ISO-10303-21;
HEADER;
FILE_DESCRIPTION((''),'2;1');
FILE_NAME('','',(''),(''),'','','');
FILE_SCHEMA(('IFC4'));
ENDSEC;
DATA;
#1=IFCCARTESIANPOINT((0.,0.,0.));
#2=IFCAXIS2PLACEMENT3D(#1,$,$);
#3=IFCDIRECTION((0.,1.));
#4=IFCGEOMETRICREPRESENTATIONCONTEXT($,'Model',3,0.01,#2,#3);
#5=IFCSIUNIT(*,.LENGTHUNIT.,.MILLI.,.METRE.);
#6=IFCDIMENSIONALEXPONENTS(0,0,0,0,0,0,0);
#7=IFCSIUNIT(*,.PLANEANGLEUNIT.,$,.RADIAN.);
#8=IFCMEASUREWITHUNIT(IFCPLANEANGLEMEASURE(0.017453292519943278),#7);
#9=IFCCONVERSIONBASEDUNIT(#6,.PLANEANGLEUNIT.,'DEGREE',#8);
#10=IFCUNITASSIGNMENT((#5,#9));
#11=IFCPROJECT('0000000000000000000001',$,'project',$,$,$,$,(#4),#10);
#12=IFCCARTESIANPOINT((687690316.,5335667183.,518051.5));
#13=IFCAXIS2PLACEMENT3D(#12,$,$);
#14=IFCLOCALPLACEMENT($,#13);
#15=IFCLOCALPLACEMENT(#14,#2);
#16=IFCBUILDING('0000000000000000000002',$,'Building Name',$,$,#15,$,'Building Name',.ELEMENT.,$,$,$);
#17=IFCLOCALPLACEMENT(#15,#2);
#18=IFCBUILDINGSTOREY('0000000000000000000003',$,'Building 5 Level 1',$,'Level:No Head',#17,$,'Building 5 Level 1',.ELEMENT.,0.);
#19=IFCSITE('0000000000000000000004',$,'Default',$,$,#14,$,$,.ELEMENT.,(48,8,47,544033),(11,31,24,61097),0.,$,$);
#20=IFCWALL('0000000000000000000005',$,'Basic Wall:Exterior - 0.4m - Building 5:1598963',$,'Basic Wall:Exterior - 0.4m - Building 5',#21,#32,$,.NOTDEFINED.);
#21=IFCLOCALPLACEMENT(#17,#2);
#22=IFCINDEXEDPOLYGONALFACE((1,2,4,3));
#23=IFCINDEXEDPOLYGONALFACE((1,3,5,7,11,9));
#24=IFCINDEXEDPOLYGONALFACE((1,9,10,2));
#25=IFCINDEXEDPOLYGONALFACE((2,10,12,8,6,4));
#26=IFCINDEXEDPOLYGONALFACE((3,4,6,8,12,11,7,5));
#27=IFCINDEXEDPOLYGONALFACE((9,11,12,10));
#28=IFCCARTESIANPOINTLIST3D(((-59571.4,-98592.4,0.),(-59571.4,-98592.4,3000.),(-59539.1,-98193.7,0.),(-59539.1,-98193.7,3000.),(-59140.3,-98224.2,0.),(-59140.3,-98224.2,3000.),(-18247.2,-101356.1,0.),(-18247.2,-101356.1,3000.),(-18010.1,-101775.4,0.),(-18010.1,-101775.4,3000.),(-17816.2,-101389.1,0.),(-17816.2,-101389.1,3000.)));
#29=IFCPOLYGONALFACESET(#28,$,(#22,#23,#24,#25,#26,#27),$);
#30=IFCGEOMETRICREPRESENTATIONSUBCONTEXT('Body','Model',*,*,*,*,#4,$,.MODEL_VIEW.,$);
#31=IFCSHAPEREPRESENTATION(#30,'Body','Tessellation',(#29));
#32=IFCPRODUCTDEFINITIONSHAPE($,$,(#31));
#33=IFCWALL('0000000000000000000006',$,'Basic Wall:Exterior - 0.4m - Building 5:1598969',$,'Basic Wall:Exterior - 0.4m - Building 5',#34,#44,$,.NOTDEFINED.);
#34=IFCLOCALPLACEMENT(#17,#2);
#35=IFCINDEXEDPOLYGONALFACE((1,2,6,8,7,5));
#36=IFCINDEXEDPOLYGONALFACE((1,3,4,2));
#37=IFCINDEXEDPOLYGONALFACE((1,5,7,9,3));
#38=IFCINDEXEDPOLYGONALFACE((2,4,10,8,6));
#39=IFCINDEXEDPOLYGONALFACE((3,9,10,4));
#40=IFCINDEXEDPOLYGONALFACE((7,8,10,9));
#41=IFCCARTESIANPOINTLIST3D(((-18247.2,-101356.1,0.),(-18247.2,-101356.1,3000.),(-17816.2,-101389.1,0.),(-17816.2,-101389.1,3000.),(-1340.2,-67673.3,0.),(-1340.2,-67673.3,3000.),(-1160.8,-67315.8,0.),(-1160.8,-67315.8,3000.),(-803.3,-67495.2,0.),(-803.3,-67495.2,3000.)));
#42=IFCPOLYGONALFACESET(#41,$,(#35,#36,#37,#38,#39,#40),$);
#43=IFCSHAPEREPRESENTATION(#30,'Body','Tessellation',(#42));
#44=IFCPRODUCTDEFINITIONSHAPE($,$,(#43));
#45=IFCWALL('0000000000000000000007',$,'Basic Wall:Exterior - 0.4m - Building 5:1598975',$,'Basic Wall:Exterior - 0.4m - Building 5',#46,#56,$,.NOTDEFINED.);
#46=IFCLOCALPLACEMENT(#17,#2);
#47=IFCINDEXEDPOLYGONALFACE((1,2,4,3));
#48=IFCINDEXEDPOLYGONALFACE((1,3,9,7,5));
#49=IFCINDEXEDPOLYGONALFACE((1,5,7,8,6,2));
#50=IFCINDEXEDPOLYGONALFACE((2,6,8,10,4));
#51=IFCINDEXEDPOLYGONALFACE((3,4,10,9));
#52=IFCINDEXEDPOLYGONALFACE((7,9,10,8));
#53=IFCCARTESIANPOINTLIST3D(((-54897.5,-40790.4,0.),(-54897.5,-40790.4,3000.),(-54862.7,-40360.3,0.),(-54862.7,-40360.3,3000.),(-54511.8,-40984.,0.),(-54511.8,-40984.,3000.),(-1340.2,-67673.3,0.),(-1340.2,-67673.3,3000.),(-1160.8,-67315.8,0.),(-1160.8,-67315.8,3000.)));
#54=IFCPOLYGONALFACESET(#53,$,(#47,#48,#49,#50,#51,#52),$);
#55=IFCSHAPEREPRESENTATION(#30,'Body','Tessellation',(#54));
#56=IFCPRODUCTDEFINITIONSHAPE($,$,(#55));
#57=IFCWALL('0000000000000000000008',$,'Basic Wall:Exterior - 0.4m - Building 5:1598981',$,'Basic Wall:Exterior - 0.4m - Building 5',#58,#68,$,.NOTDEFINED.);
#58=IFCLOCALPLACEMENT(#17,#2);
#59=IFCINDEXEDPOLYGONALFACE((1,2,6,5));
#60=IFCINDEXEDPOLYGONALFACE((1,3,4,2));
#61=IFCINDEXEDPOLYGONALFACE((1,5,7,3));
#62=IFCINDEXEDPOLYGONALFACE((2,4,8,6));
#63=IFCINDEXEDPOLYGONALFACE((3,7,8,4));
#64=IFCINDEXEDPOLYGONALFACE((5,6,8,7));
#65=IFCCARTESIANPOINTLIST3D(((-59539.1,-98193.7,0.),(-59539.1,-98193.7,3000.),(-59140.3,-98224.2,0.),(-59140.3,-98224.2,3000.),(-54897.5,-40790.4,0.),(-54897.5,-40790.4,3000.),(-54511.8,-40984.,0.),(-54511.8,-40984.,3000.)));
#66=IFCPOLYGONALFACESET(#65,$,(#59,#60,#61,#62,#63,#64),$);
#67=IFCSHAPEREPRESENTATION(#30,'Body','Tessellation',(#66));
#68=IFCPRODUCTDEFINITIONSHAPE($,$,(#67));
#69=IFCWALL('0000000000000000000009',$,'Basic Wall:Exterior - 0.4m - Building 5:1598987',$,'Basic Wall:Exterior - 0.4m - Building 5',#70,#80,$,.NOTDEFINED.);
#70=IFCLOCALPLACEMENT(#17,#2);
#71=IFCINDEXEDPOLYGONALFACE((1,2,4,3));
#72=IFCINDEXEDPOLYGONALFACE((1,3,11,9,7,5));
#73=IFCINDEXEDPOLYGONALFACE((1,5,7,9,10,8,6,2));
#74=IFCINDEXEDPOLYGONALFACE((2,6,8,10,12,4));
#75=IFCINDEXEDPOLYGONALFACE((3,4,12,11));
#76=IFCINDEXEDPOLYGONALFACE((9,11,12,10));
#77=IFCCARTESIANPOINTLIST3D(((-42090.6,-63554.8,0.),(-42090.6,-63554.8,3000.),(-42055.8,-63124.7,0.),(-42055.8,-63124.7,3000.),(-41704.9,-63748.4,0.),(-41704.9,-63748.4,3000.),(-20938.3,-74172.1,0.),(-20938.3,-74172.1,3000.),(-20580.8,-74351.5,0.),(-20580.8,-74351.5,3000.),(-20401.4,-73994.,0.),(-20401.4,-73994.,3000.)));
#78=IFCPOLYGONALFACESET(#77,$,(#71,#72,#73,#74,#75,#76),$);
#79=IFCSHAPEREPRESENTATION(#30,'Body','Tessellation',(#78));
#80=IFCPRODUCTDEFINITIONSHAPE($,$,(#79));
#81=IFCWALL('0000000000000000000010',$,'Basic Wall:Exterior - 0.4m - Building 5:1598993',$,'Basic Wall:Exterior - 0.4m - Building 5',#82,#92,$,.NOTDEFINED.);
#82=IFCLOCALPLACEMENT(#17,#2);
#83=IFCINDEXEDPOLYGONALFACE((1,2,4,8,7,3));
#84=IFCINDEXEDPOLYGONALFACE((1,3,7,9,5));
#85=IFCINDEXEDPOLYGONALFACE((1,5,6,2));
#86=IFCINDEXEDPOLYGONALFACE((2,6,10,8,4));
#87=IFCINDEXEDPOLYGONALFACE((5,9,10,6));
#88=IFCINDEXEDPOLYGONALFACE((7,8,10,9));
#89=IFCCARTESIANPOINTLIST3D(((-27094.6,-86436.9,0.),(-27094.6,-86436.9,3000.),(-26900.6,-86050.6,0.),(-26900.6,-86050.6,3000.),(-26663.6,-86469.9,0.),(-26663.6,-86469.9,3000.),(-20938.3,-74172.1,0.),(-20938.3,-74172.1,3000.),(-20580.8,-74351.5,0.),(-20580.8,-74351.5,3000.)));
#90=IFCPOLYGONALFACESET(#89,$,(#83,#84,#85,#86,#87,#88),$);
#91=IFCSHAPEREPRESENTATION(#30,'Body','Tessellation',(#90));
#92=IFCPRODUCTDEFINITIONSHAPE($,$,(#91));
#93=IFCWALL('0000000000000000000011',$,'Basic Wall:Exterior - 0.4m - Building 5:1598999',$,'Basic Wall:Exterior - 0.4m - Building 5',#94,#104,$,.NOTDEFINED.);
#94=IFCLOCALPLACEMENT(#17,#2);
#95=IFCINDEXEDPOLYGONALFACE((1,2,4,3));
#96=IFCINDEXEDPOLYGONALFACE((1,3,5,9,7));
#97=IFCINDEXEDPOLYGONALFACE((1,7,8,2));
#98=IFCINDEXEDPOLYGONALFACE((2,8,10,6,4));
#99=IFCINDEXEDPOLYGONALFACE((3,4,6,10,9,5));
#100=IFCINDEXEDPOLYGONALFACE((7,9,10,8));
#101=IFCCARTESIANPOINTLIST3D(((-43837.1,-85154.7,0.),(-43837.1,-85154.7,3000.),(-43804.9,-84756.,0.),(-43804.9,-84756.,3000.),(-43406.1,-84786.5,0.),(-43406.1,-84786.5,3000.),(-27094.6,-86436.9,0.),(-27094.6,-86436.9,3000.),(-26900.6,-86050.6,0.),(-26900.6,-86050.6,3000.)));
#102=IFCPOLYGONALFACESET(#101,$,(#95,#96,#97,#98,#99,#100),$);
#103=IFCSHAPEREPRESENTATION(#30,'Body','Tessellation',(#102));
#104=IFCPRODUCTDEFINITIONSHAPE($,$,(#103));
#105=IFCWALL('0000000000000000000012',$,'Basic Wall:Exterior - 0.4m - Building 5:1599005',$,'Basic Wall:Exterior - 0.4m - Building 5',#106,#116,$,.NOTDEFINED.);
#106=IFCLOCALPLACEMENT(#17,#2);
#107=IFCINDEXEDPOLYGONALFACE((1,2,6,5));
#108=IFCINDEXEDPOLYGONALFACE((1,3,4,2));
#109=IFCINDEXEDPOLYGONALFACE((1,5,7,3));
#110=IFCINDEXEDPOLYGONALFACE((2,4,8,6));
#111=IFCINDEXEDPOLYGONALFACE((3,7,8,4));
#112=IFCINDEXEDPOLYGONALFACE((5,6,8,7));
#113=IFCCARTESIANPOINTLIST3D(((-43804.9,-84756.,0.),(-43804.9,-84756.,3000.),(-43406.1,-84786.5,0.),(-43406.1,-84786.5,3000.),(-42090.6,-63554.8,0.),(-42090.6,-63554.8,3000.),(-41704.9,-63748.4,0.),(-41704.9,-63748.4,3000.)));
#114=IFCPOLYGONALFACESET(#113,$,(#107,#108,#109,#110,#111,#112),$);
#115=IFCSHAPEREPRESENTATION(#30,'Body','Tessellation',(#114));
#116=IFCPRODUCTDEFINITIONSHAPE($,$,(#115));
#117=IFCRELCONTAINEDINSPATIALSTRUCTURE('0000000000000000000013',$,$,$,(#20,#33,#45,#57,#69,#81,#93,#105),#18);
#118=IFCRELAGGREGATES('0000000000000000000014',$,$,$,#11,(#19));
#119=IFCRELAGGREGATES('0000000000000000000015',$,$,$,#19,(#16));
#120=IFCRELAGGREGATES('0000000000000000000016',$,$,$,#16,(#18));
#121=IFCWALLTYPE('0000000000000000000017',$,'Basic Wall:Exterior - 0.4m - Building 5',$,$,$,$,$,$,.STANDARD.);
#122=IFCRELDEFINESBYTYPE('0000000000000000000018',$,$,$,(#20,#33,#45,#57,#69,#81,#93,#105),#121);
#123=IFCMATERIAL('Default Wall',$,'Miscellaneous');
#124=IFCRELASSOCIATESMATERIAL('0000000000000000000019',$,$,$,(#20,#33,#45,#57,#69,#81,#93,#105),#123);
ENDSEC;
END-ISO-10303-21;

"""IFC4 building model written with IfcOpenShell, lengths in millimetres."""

from ifc_helpers import new_model, entity, si_unit, converted_unit, direction, frame, origin, place, context, subcontext, project, spatial, indexed_curve, outline, extrude, material, type_object, element, save


model = new_model("IFC4")

# Units and contexts
model_context = context("Model", 3, precision=0.01, world=origin(), true_north=direction((0.0, 1.0)))
body_context = subcontext(model_context, "Body", "Model", "MODEL_VIEW")
ifc_project = project(units=[si_unit("LENGTHUNIT", "METRE", prefix="MILLI"), converted_unit("PLANEANGLEUNIT", "DEGREE", entity("IfcPlaneAngleMeasure", 0.017453292519943278), si_unit("PLANEANGLEUNIT", "RADIAN"), dimensions=[0, 0, 0, 0, 0, 0, 0])], contexts=[model_context])

# Site, building, storey
site_placement = place(None, frame((687690316.0, 5335667183.0, 518051.5)))
site = spatial("IfcSite", under=ifc_project, at=site_placement, Name="Default", CompositionType="ELEMENT", RefLatitude=(48, 8, 47, 544033), RefLongitude=(11, 31, 24, 61097), RefElevation=0.0)
building_placement = place(site_placement, origin())
building = spatial("IfcBuilding", under=site, at=building_placement, Name="Building Name", LongName="Building Name", CompositionType="ELEMENT")
storey_placement = place(building_placement, origin())
storey = spatial("IfcBuildingStorey", under=building, at=storey_placement, Name="Building 5 Level 1", ObjectType="Level:No Head", LongName="Building 5 Level 1", CompositionType="ELEMENT", Elevation=0.0)

# Walls
ifc_material_1 = material(Name="Default Wall", Category="Miscellaneous")
wall_type = type_object("IfcWallType", Name="Basic Wall:Exterior - 0.4m - Building 5", PredefinedType="STANDARD")
wall_1_placement = place(storey_placement, frame((-59556.1, -98393.0, 0.0), z_axis=(0.0, 0.0, 1.0), x_axis=(0.99708, -0.076363, 0.0)))
element("IfcWall", 1, at=wall_1_placement, inside=storey, type_object=wall_type, material=ifc_material_1, Name="Basic Wall:Exterior - 0.4m - Building 5:1598963", ObjectType="Basic Wall:Exterior - 0.4m - Building 5", PredefinedType="NOTDEFINED", context=body_context, shape_type="SweptSolid", body=[
    extrude(outline(indexed_curve([(41683.0, -200.0), (41846.9, 200.0), (41414.6, 200.0), (401.7, 200.0), (1.7, 200.0), (0.0, -200.0), (41683.0, -200.0)], self_intersect=False)), origin(), (0.0, 0.0, 1.0), 3000.0),
])
wall_2_placement = place(storey_placement, frame((-18068.4, -101445.8, 0.0), z_axis=(0.0, 0.0, 1.0), x_axis=(0.448604, 0.893731, 0.0)))
element("IfcWall", 2, at=wall_2_placement, inside=storey, type_object=wall_type, material=ifc_material_1, Name="Basic Wall:Exterior - 0.4m - Building 5:1598969", ObjectType="Basic Wall:Exterior - 0.4m - Building 5", PredefinedType="NOTDEFINED", context=body_context, shape_type="SweptSolid", body=[
    extrude(outline(indexed_curve([(38087.9, -200.0), (38087.9, 200.0), (37687.9, 200.0), (0.0, 200.0), (163.8, -200.0), (38087.9, -200.0)], self_intersect=False)), origin(), (0.0, 0.0, 1.0), 3000.0),
])
wall_3_placement = place(storey_placement, frame((-1250.5, -67494.5, 0.0), z_axis=(0.0, 0.0, 1.0), x_axis=(-0.893731, 0.448604, 0.0)))
element("IfcWall", 3, at=wall_3_placement, inside=storey, type_object=wall_type, material=ifc_material_1, Name="Basic Wall:Exterior - 0.4m - Building 5:1598975", ObjectType="Basic Wall:Exterior - 0.4m - Building 5", PredefinedType="NOTDEFINED", context=body_context, shape_type="SweptSolid", body=[
    extrude(outline(indexed_curve([(60087.4, -200.0), (59925.5, 200.0), (59494.0, 200.0), (0.0, 200.0), (0.0, -200.0), (60087.4, -200.0)], self_intersect=False)), origin(), (0.0, 0.0, 1.0), 3000.0),
])
wall_4_placement = place(storey_placement, frame((-54698.1, -40806.5, 0.0), z_axis=(0.0, 0.0, 1.0), x_axis=(-0.080597, -0.996747, 0.0)))
element("IfcWall", 4, at=wall_4_placement, inside=storey, type_object=wall_type, material=ifc_material_1, Name="Basic Wall:Exterior - 0.4m - Building 5:1598981", ObjectType="Basic Wall:Exterior - 0.4m - Building 5", PredefinedType="NOTDEFINED", context=body_context, shape_type="SweptSolid", body=[
    extrude(outline(indexed_curve([(57590.6, -200.0), (57588.9, 200.0), (161.9, 200.0), (0.0, -200.0), (57590.6, -200.0)], self_intersect=False)), origin(), (0.0, 0.0, 1.0), 3000.0),
])
wall_5_placement = place(storey_placement, frame((-42145.5, -63303.4, 0.0), z_axis=(0.0, 0.0, 1.0), x_axis=(0.893731, -0.448604, 0.0)))
element("IfcWall", 5, at=wall_5_placement, inside=storey, type_object=wall_type, material=ifc_material_1, Name="Basic Wall:Exterior - 0.4m - Building 5:1598987", ObjectType="Basic Wall:Exterior - 0.4m - Building 5", PredefinedType="NOTDEFINED", context=body_context, shape_type="SweptSolid", body=[
    extrude(outline(indexed_curve([(24229.3, -200.0), (24229.3, 200.0), (0.0, 200.0), (161.9, -200.0), (593.4, -200.0), (23829.3, -200.0), (24229.3, -200.0)], self_intersect=False)), origin(), (0.0, 0.0, 1.0), 3000.0),
])
wall_6_placement = place(storey_placement, frame((-20759.5, -74261.8, 0.0), z_axis=(0.0, 0.0, 1.0), x_axis=(-0.448604, -0.893731, 0.0)))
element("IfcWall", 6, at=wall_6_placement, inside=storey, type_object=wall_type, material=ifc_material_1, Name="Basic Wall:Exterior - 0.4m - Building 5:1598993", ObjectType="Basic Wall:Exterior - 0.4m - Building 5", PredefinedType="NOTDEFINED", context=body_context, shape_type="SweptSolid", body=[
    extrude(outline(indexed_curve([(13723.2, -200.0), (13559.3, 200.0), (0.0, 200.0), (0.0, -200.0), (13290.9, -200.0), (13723.2, -200.0)], self_intersect=False)), origin(), (0.0, 0.0, 1.0), 3000.0),
])
wall_7_placement = place(storey_placement, frame((-26915.9, -86250.0, 0.0), z_axis=(0.0, 0.0, 1.0), x_axis=(-0.99708, 0.076363, 0.0)))
element("IfcWall", 7, at=wall_7_placement, inside=storey, type_object=wall_type, material=ifc_material_1, Name="Basic Wall:Exterior - 0.4m - Building 5:1598999", ObjectType="Basic Wall:Exterior - 0.4m - Building 5", PredefinedType="NOTDEFINED", context=body_context, shape_type="SweptSolid", body=[
    extrude(outline(indexed_curve([(16953.8, -200.0), (16955.5, 200.0), (163.8, 200.0), (0.0, -200.0), (16553.8, -200.0), (16953.8, -200.0)], self_intersect=False)), origin(), (0.0, 0.0, 1.0), 3000.0),
])
wall_8_placement = place(storey_placement, frame((-43605.6, -84772.1, 0.0), z_axis=(0.0, 0.0, 1.0), x_axis=(0.080597, 0.996747, 0.0)))
element("IfcWall", 8, at=wall_8_placement, inside=storey, type_object=wall_type, material=ifc_material_1, Name="Basic Wall:Exterior - 0.4m - Building 5:1599005", ObjectType="Basic Wall:Exterior - 0.4m - Building 5", PredefinedType="NOTDEFINED", context=body_context, shape_type="SweptSolid", body=[
    extrude(outline(indexed_curve([(21108.5, -200.0), (21270.4, 200.0), (0.0, 200.0), (1.7, -200.0), (21108.5, -200.0)], self_intersect=False)), origin(), (0.0, 0.0, 1.0), 3000.0),
])

save(model, "model.ifc")
